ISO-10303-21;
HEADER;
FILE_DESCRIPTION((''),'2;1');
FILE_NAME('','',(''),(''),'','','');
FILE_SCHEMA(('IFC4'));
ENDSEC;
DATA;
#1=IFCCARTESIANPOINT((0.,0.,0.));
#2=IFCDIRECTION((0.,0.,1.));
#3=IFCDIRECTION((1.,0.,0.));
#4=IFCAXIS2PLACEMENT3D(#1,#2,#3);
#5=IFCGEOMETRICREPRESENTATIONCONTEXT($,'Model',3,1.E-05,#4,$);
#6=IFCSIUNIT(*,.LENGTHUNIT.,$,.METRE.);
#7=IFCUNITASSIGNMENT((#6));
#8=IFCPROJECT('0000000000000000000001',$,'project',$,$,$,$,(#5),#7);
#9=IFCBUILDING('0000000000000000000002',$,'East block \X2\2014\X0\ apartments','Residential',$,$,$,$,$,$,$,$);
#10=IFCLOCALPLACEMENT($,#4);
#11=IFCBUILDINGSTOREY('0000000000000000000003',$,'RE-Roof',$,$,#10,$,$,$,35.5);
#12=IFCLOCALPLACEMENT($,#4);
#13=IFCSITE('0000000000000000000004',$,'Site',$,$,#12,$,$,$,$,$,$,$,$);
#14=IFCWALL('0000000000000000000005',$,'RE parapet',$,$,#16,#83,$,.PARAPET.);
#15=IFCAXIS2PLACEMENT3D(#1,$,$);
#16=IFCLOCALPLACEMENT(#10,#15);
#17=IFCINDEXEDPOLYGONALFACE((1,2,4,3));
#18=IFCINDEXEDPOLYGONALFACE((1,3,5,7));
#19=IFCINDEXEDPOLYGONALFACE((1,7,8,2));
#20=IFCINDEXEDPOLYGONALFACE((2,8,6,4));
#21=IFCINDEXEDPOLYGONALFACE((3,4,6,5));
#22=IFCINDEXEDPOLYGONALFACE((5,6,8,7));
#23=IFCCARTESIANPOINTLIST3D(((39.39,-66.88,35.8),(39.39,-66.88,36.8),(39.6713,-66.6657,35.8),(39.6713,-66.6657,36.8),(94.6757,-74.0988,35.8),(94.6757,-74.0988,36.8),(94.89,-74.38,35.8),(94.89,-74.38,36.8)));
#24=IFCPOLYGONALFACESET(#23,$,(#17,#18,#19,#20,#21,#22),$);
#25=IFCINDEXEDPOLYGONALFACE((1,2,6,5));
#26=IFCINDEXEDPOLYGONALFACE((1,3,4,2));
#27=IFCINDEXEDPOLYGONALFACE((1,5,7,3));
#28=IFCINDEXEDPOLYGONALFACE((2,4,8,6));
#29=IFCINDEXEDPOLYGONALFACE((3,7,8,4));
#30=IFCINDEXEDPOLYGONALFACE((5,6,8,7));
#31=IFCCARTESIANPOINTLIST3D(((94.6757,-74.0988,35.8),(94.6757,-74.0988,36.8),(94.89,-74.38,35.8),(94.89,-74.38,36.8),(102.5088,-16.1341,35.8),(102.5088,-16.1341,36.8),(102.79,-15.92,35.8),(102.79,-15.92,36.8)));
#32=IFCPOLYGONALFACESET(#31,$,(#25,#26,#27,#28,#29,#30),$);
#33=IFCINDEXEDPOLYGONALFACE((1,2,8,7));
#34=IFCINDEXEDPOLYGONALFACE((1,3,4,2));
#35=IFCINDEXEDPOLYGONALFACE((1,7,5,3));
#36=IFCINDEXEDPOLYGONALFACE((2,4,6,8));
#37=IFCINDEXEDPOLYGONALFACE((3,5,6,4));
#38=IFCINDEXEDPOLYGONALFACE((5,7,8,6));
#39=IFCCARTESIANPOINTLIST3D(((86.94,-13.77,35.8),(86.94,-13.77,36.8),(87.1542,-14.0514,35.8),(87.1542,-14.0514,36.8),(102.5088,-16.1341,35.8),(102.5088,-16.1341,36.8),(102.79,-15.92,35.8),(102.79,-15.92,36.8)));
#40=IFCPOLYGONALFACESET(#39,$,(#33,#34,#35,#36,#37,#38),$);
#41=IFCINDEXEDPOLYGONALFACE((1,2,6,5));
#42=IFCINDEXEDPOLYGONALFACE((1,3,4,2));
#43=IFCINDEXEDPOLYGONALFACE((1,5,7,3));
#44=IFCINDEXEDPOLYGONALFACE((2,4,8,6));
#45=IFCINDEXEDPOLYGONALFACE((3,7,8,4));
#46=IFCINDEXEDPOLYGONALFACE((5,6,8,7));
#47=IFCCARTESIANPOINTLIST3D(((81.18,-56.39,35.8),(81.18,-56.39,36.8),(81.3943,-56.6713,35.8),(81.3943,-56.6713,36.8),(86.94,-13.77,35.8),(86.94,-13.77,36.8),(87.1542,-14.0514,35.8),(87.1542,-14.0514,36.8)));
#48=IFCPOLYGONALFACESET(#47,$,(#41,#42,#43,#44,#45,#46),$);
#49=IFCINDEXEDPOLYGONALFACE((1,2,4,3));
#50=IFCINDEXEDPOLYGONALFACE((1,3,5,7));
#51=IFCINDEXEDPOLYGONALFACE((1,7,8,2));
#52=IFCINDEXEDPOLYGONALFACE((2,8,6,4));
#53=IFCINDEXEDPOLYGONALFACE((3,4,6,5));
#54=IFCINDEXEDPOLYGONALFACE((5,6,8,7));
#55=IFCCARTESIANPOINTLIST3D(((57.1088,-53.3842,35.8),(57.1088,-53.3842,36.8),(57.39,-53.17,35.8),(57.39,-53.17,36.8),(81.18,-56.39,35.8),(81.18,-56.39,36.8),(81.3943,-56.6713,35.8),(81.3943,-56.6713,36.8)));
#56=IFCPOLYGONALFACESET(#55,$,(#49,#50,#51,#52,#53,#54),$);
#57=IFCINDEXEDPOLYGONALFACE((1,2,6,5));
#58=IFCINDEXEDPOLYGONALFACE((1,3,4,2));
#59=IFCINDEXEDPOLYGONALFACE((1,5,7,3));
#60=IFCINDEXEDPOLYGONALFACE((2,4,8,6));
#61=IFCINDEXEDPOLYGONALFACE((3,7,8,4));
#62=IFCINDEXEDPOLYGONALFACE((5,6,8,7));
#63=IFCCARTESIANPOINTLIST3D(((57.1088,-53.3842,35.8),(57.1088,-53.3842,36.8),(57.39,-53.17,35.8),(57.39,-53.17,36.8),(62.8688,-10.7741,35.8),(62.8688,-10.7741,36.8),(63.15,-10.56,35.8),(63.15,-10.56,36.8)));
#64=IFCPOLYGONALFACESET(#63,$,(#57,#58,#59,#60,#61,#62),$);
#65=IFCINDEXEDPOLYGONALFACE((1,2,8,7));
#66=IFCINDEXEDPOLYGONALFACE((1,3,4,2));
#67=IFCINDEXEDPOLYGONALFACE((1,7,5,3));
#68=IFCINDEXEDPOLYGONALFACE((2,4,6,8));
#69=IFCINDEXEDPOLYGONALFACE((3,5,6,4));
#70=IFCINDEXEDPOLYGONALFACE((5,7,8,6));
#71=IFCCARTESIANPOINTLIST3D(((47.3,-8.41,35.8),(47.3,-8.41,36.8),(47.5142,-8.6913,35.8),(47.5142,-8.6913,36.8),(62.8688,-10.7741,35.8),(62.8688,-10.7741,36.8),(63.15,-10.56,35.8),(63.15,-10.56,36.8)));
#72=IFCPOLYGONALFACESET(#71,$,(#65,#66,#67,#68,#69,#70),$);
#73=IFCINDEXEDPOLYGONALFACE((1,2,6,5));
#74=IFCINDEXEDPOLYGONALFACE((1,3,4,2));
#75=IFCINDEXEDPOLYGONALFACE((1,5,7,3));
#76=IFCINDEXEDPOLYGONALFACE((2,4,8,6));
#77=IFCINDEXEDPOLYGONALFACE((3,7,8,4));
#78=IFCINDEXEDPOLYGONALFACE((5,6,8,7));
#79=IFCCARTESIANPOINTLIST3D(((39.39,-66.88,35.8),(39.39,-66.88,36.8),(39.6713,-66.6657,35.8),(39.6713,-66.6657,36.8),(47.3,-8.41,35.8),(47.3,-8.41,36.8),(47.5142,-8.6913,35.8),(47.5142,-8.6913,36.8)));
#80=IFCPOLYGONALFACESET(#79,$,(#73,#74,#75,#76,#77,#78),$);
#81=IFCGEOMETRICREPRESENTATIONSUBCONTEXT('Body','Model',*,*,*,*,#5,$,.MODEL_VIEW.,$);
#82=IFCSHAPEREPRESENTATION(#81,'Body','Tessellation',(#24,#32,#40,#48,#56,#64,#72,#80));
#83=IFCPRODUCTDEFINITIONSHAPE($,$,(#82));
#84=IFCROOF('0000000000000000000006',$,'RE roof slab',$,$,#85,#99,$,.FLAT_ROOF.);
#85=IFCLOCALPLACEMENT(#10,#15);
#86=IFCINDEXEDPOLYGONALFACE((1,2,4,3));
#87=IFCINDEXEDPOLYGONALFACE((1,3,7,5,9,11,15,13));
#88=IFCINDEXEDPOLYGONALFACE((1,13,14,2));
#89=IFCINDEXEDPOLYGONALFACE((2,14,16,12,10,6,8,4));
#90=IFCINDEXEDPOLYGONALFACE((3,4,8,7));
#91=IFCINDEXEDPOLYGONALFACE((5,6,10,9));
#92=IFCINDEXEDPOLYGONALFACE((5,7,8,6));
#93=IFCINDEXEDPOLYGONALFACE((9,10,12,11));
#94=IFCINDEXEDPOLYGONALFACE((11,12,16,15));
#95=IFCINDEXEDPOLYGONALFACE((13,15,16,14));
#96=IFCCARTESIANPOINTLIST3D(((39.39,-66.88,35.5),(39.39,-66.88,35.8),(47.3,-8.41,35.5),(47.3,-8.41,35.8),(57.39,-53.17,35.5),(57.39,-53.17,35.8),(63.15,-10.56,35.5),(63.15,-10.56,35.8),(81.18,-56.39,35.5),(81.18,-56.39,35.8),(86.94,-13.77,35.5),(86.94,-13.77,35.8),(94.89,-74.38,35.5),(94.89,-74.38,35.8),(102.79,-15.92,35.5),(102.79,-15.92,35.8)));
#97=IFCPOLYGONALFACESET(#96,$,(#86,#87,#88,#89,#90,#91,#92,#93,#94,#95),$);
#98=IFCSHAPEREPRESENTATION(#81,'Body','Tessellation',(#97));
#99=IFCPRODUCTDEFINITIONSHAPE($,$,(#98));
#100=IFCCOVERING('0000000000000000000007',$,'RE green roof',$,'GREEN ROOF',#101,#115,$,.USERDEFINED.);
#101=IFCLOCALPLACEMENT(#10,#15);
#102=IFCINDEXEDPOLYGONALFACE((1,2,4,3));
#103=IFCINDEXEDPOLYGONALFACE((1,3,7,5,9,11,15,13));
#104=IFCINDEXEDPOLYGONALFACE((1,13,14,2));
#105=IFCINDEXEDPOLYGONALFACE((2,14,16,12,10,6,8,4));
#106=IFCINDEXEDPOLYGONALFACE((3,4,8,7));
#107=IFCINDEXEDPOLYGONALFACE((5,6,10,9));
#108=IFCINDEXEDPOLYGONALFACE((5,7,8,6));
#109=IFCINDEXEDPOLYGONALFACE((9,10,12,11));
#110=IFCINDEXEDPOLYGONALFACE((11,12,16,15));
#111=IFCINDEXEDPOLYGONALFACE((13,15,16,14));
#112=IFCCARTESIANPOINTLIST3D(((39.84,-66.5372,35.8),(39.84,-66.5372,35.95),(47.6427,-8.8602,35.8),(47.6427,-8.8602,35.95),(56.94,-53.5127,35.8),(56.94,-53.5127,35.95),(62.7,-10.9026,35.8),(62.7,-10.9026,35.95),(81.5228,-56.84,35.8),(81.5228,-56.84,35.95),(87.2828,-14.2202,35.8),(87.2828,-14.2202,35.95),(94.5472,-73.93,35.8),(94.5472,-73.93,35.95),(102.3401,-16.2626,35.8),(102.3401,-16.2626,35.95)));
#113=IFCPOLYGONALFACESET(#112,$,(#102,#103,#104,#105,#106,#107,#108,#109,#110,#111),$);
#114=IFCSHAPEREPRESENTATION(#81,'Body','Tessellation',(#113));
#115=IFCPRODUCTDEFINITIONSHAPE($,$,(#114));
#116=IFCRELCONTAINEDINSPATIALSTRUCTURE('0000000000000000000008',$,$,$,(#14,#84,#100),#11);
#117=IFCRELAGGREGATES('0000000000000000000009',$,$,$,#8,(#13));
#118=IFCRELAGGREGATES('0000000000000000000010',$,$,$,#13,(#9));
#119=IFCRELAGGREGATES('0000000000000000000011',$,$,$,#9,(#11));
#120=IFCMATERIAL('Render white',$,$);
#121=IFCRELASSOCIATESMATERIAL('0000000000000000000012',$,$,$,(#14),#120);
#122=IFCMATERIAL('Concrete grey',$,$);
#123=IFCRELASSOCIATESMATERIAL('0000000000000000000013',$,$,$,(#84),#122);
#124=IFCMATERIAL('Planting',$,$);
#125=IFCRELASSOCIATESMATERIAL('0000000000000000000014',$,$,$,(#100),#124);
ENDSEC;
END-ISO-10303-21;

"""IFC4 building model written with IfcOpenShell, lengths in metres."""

from ifc_helpers import new_model, si_unit, frame, origin_with_axes, place, context, subcontext, project, spatial, polyline, outline, extrude, material, element, save


model = new_model("IFC4")

# Units and contexts
model_context = context("Model", 3, precision=1e-05, world=origin_with_axes())
body_context = subcontext(model_context, "Body", "Model", "MODEL_VIEW")
ifc_project = project(units=[si_unit("LENGTHUNIT", "METRE")], contexts=[model_context])

# Site, building, storey
site_placement = place(None, origin_with_axes())
site = spatial("IfcSite", under=ifc_project, at=site_placement, Name="Site")
building = spatial("IfcBuilding", under=site, Name="East block — apartments", Description="Residential")
storey_placement = place(None, origin_with_axes())
storey = spatial("IfcBuildingStorey", under=building, at=storey_placement, Name="RE-Roof", Elevation=35.5)

# Wall
ifc_material_1 = material(Name="Render white")
wall_placement = place(storey_placement, origin_with_axes())
element("IfcWall", 1, at=wall_placement, inside=storey, material=ifc_material_1, Name="RE parapet", PredefinedType="PARAPET", context=body_context, shape_type="SweptSolid", body=[
    extrude(outline(polyline([(39.39, -66.88), (94.89, -74.38), (94.6757, -74.0988), (39.6713, -66.6657), (39.39, -66.88)])), frame((0.0, 0.0, 35.8), z_axis=(0.0, 0.0, 1.0), x_axis=(1.0, 0.0, 0.0)), (0.0, 0.0, 1.0), 1.0),
    extrude(outline(polyline([(94.89, -74.38), (102.79, -15.92), (102.5088, -16.1341), (94.6757, -74.0988), (94.89, -74.38)])), frame((0.0, 0.0, 35.8), z_axis=(0.0, 0.0, 1.0), x_axis=(1.0, 0.0, 0.0)), (0.0, 0.0, 1.0), 1.0),
    extrude(outline(polyline([(102.79, -15.92), (86.94, -13.77), (87.1542, -14.0514), (102.5088, -16.1341), (102.79, -15.92)])), frame((0.0, 0.0, 35.8), z_axis=(0.0, 0.0, 1.0), x_axis=(1.0, 0.0, 0.0)), (0.0, 0.0, 1.0), 1.0),
    extrude(outline(polyline([(86.94, -13.77), (81.18, -56.39), (81.3943, -56.6713), (87.1542, -14.0514), (86.94, -13.77)])), frame((0.0, 0.0, 35.8), z_axis=(0.0, 0.0, 1.0), x_axis=(1.0, 0.0, 0.0)), (0.0, 0.0, 1.0), 1.0),
    extrude(outline(polyline([(81.18, -56.39), (57.39, -53.17), (57.1088, -53.3842), (81.3943, -56.6713), (81.18, -56.39)])), frame((0.0, 0.0, 35.8), z_axis=(0.0, 0.0, 1.0), x_axis=(1.0, 0.0, 0.0)), (0.0, 0.0, 1.0), 1.0),
    extrude(outline(polyline([(57.39, -53.17), (63.15, -10.56), (62.8688, -10.7741), (57.1088, -53.3842), (57.39, -53.17)])), frame((0.0, 0.0, 35.8), z_axis=(0.0, 0.0, 1.0), x_axis=(1.0, 0.0, 0.0)), (0.0, 0.0, 1.0), 1.0),
    extrude(outline(polyline([(63.15, -10.56), (47.3, -8.41), (47.5142, -8.6913), (62.8688, -10.7741), (63.15, -10.56)])), frame((0.0, 0.0, 35.8), z_axis=(0.0, 0.0, 1.0), x_axis=(1.0, 0.0, 0.0)), (0.0, 0.0, 1.0), 1.0),
    extrude(outline(polyline([(47.3, -8.41), (39.39, -66.88), (39.6713, -66.6657), (47.5142, -8.6913), (47.3, -8.41)])), frame((0.0, 0.0, 35.8), z_axis=(0.0, 0.0, 1.0), x_axis=(1.0, 0.0, 0.0)), (0.0, 0.0, 1.0), 1.0),
])

# Roof
ifc_material_2 = material(Name="Concrete grey")
roof_placement = place(storey_placement, origin_with_axes())
element("IfcRoof", 2, at=roof_placement, inside=storey, material=ifc_material_2, Name="RE roof slab", PredefinedType="FLAT_ROOF", context=body_context, shape_type="SweptSolid", body=[
    extrude(outline(polyline([(39.39, -66.88), (94.89, -74.38), (102.79, -15.92), (86.94, -13.77), (81.18, -56.39), (57.39, -53.17), (63.15, -10.56), (47.3, -8.41), (39.39, -66.88)])), frame((0.0, 0.0, 35.5), z_axis=(0.0, 0.0, 1.0), x_axis=(1.0, 0.0, 0.0)), (0.0, 0.0, 1.0), 0.3),
])

# Covering
ifc_material_3 = material(Name="Planting")
covering_placement = place(storey_placement, origin_with_axes())
element("IfcCovering", 3, at=covering_placement, inside=storey, material=ifc_material_3, Name="RE green roof", ObjectType="GREEN ROOF", PredefinedType="USERDEFINED", context=body_context, shape_type="SweptSolid", body=[
    extrude(outline(polyline([(39.84, -66.5372), (94.5472, -73.93), (102.3401, -16.2626), (87.2828, -14.2202), (81.5228, -56.84), (56.94, -53.5127), (62.7, -10.9026), (47.6427, -8.8602), (39.84, -66.5372)])), frame((0.0, 0.0, 35.8), z_axis=(0.0, 0.0, 1.0), x_axis=(1.0, 0.0, 0.0)), (0.0, 0.0, 1.0), 0.15),
])

save(model, "model.ifc")
